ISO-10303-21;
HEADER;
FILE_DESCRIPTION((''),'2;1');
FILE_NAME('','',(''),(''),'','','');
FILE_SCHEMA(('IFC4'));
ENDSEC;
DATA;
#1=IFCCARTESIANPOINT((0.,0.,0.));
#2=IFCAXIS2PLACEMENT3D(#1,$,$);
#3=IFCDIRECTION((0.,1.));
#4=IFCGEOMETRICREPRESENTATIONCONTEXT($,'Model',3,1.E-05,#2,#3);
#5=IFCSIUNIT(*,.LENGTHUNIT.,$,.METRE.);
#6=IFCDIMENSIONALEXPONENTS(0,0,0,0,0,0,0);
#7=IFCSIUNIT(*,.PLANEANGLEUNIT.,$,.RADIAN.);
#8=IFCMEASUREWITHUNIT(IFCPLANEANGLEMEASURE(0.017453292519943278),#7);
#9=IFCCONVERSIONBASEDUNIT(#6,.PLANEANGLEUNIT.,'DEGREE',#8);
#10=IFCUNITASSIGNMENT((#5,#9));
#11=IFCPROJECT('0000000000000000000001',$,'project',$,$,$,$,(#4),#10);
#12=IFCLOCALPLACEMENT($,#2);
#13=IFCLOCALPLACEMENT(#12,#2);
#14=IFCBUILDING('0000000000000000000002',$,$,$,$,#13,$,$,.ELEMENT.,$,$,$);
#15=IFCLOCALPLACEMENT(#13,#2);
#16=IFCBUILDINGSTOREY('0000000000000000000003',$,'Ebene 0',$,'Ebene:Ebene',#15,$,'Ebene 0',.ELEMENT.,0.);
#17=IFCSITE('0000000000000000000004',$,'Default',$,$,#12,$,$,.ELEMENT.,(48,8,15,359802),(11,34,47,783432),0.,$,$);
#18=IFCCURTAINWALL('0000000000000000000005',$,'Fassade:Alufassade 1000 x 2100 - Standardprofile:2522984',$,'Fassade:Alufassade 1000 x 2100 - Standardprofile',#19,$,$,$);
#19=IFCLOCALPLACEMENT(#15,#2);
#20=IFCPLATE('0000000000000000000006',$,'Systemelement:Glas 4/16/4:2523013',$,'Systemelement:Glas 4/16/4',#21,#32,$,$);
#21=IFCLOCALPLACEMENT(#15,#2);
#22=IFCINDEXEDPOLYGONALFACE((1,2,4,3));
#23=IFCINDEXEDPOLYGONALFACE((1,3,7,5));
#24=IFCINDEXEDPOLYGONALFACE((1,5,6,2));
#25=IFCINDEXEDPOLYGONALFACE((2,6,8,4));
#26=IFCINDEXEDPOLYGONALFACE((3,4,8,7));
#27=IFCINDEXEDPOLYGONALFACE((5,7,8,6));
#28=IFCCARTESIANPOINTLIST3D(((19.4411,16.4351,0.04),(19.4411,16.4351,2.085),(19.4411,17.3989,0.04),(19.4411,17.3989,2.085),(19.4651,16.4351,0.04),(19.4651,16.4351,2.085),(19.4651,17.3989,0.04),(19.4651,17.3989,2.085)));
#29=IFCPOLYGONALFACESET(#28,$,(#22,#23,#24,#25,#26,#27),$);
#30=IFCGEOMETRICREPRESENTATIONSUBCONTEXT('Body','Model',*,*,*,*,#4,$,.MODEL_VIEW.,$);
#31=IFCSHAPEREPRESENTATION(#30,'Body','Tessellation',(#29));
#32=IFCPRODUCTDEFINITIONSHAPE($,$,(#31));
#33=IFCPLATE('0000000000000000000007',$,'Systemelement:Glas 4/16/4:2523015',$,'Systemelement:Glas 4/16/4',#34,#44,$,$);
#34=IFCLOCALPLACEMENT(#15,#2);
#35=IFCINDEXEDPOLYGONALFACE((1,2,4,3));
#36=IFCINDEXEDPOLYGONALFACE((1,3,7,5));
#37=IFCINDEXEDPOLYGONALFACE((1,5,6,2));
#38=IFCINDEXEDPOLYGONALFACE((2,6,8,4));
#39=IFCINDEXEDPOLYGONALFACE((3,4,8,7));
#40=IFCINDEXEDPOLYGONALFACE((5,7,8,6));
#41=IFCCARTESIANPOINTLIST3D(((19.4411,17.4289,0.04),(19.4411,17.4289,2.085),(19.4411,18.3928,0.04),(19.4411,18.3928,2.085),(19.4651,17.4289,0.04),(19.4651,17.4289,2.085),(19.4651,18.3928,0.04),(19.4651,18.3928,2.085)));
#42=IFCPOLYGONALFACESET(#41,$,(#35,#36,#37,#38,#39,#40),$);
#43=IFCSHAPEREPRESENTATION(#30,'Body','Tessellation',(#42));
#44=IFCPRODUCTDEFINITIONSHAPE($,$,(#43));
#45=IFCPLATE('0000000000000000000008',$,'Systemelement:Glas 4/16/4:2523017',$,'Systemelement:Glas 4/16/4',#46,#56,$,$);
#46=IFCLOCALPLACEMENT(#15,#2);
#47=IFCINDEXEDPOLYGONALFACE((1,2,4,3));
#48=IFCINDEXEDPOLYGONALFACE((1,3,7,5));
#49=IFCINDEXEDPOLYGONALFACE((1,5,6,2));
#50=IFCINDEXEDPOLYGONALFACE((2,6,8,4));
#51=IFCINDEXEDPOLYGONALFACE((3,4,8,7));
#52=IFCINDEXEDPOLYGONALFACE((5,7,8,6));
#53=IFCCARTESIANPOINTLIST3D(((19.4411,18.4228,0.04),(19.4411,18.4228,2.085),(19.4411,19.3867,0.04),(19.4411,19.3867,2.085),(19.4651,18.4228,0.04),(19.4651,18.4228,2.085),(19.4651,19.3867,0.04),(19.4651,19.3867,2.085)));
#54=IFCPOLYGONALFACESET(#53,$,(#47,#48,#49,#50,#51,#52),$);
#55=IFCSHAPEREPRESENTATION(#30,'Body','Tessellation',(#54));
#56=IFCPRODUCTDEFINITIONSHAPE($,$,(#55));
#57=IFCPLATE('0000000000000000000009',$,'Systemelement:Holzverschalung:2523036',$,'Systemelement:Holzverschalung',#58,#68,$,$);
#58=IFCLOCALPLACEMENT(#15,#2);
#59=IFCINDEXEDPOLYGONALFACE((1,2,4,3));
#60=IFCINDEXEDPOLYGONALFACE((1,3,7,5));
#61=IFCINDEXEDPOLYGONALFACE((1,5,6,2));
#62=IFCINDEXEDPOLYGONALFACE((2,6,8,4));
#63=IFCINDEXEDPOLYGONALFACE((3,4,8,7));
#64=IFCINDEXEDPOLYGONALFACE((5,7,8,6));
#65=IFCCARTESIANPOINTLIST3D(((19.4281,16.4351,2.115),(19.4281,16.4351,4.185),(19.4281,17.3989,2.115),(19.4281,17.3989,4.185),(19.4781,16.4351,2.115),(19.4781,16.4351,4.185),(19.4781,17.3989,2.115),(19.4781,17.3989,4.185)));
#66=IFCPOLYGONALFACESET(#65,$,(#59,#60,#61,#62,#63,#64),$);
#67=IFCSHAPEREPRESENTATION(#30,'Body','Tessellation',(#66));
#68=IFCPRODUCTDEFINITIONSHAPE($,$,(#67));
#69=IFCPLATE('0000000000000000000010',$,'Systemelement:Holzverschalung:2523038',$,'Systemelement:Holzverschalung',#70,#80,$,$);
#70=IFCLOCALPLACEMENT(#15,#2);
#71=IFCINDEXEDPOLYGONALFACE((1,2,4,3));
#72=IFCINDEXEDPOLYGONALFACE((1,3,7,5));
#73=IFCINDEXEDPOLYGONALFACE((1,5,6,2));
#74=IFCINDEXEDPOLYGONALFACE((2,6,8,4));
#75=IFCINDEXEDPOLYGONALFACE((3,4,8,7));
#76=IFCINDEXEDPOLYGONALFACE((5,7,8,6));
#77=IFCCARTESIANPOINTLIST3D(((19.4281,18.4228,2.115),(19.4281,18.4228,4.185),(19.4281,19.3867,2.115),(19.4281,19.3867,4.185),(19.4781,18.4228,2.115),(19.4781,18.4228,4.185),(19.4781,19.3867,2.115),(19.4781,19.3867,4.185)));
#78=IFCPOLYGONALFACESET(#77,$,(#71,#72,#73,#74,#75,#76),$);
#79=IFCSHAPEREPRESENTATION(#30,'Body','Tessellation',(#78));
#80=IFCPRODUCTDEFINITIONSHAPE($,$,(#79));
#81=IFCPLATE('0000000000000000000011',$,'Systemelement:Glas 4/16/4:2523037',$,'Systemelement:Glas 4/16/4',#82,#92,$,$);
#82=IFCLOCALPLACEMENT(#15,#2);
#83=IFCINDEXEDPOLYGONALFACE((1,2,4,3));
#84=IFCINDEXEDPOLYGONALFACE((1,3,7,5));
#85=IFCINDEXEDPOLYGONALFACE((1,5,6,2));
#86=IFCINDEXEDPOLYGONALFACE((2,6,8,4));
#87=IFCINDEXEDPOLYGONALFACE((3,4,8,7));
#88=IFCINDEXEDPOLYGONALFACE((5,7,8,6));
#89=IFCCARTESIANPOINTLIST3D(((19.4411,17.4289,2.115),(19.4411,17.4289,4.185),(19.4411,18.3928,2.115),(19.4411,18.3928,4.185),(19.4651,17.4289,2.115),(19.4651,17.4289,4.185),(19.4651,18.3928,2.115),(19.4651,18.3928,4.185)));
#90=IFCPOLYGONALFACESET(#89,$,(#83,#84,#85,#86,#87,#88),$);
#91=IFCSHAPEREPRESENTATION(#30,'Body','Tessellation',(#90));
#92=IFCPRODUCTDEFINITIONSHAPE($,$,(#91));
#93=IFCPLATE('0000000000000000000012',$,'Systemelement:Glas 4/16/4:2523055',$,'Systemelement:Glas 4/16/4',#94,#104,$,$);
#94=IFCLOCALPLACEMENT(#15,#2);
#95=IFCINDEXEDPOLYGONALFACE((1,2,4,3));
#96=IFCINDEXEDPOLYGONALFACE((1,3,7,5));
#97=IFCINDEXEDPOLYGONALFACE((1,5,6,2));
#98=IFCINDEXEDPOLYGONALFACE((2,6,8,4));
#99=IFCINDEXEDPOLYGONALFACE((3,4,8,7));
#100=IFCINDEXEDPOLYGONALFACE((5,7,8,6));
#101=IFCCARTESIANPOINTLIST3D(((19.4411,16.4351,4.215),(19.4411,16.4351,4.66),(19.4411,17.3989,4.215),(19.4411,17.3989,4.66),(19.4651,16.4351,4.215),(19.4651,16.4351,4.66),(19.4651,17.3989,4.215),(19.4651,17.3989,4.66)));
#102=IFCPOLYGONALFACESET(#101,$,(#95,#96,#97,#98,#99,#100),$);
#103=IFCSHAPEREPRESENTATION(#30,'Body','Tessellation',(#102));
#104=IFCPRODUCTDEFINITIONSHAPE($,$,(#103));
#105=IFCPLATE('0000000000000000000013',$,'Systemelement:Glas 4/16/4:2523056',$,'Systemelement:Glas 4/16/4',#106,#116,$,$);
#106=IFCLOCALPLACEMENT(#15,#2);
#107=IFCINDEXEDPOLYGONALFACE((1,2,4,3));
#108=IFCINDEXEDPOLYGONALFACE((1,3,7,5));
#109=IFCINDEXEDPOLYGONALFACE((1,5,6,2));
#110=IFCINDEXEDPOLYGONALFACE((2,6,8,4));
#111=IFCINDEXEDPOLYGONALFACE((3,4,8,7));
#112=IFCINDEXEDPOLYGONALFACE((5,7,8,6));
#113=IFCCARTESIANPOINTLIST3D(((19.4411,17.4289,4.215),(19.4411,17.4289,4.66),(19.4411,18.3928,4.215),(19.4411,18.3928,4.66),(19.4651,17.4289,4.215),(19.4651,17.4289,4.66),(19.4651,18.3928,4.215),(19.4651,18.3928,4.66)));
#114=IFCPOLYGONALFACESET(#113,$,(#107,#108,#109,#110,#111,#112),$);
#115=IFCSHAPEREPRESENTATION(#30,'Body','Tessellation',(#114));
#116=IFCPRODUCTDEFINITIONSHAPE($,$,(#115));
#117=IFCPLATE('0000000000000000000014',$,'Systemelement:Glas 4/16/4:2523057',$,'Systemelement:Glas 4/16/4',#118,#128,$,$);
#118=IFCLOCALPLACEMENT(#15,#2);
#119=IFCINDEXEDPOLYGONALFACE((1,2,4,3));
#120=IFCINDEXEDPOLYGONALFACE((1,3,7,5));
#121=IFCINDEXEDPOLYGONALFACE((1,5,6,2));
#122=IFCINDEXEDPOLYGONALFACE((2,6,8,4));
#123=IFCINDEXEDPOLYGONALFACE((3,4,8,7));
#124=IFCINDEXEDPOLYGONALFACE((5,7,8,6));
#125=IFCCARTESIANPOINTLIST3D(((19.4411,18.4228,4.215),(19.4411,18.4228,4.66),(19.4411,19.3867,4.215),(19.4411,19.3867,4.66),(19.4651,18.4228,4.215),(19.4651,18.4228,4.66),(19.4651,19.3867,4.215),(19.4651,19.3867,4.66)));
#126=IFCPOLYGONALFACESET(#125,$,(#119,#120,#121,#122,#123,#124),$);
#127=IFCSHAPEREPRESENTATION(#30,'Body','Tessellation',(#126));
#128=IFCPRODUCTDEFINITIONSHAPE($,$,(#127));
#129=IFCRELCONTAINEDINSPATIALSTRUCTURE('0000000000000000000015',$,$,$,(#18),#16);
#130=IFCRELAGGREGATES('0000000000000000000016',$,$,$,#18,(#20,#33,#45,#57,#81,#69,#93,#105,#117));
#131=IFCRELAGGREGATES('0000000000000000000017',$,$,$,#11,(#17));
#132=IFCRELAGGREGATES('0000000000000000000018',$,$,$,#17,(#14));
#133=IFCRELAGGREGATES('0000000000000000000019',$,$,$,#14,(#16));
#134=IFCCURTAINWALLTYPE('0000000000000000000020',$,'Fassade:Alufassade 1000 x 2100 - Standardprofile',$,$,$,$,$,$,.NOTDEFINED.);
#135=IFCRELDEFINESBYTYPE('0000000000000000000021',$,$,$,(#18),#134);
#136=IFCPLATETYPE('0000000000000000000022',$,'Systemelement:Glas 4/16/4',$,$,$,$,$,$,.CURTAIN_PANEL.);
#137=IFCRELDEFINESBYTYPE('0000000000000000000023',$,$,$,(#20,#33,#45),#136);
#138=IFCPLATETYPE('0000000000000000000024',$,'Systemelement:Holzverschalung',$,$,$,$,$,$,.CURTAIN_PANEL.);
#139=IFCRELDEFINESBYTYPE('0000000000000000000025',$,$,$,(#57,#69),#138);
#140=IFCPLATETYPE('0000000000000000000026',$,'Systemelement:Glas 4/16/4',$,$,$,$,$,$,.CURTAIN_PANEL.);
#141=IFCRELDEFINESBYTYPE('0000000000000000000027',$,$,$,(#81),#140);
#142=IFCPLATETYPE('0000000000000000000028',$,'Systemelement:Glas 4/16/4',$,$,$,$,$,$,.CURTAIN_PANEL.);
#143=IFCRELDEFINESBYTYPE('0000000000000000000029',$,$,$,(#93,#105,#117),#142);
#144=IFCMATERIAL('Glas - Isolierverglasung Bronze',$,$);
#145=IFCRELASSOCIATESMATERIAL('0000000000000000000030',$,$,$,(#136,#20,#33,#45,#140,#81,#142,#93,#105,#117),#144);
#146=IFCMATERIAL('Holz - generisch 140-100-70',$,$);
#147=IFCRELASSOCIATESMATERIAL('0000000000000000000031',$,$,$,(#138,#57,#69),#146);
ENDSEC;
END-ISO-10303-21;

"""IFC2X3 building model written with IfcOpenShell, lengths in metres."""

from ifc_helpers import new_model, entity, si_unit, converted_unit, direction, frame, origin, origin_2d_with_axis, place, context, subcontext, project, spatial, rectangle, extrude, source, transform, mapped, material, type_object, type_shapes, element, aggregate, save


model = new_model("IFC2X3")

# Units and contexts
model_context = context("Model", 3, precision=1e-05, world=origin(), true_north=direction((0.0, 1.0)))
body_context = subcontext(model_context, "Body", "Model", "MODEL_VIEW")
ifc_project = project(units=[si_unit("LENGTHUNIT", "METRE"), converted_unit("PLANEANGLEUNIT", "DEGREE", entity("IfcPlaneAngleMeasure", 0.017453292519943278), si_unit("PLANEANGLEUNIT", "RADIAN"), dimensions=[0, 0, 0, 0, 0, 0, 0])], contexts=[model_context])

# Site, building, storey
site_placement = place(None, origin())
site = spatial("IfcSite", under=ifc_project, at=site_placement, Name="Default", CompositionType="ELEMENT", RefLatitude=(48, 8, 15, 359802), RefLongitude=(11, 34, 47, 783432), RefElevation=0.0)
building_placement = place(site_placement, origin())
building = spatial("IfcBuilding", under=site, at=building_placement, CompositionType="ELEMENT")
storey_placement = place(building_placement, origin())
storey = spatial("IfcBuildingStorey", under=building, at=storey_placement, Name="Ebene 0", ObjectType="Ebene:Ebene", LongName="Ebene 0", CompositionType="ELEMENT", Elevation=0.0)

# Curtain wall, plates
curtain_wall_type = type_object("IfcCurtainWallType", Name="Fassade:Alufassade 1000 x 2100 - Standardprofile", PredefinedType="NOTDEFINED")
curtain_wall_placement = place(storey_placement, origin())
curtain_wall = element("IfcCurtainWall", 1, at=curtain_wall_placement, inside=storey, type_object=curtain_wall_type, Name="Fassade:Alufassade 1000 x 2100 - Standardprofile:2522984", ObjectType="Fassade:Alufassade 1000 x 2100 - Standardprofile")
ifc_material_1 = material(Name="Glas - Isolierverglasung Bronze")
plate_type_1 = type_object("IfcPlateType", Name="Systemelement:Glas 4/16/4", PredefinedType="CURTAIN_PANEL", material=ifc_material_1)
shared_shape_1 = source(origin(), body_context, "Body", "SweptSolid", [
    extrude(rectangle(XDim=0.024, YDim=0.9639, at=origin_2d_with_axis()), frame((0.0, 0.0, 0.0), z_axis=(0.0, 0.0, 1.0), x_axis=(0.0, 1.0, 0.0)), (0.0, 0.0, 1.0), 2.045),
])
type_shapes(plate_type_1, [shared_shape_1])
plate_1_placement = place(curtain_wall_placement, frame((19.4531, 16.917, 0.04), z_axis=(0.0, 0.0, 1.0), x_axis=(0.0, 1.0, 0.0)))
plate_1 = element("IfcPlate", 2, at=plate_1_placement, type_object=plate_type_1, material=ifc_material_1, Name="Systemelement:Glas 4/16/4:2523013", ObjectType="Systemelement:Glas 4/16/4", context=body_context, shape_type="MappedRepresentation", body=[
    mapped(shared_shape_1, transform((0.0, 0.0, 0.0), scale=1.0)),
])
plate_2_placement = place(curtain_wall_placement, frame((19.4531, 17.9109, 0.04), z_axis=(0.0, 0.0, 1.0), x_axis=(0.0, 1.0, 0.0)))
plate_2 = element("IfcPlate", 3, at=plate_2_placement, type_object=plate_type_1, material=ifc_material_1, Name="Systemelement:Glas 4/16/4:2523015", ObjectType="Systemelement:Glas 4/16/4", context=body_context, shape_type="MappedRepresentation", body=[
    mapped(shared_shape_1, transform((0.0, 0.0, 0.0), scale=1.0)),
])
plate_3_placement = place(curtain_wall_placement, frame((19.4531, 18.9048, 0.04), z_axis=(0.0, 0.0, 1.0), x_axis=(0.0, 1.0, 0.0)))
plate_3 = element("IfcPlate", 4, at=plate_3_placement, type_object=plate_type_1, material=ifc_material_1, Name="Systemelement:Glas 4/16/4:2523017", ObjectType="Systemelement:Glas 4/16/4", context=body_context, shape_type="MappedRepresentation", body=[
    mapped(shared_shape_1, transform((0.0, 0.0, 0.0), scale=1.0)),
])
ifc_material_2 = material(Name="Holz - generisch 140-100-70")
plate_type_2 = type_object("IfcPlateType", Name="Systemelement:Holzverschalung", PredefinedType="CURTAIN_PANEL", material=ifc_material_2)
shared_shape_2 = source(origin(), body_context, "Body", "SweptSolid", [
    extrude(rectangle(XDim=0.05, YDim=0.9639, at=origin_2d_with_axis()), frame((0.0, 0.0, 0.0), z_axis=(0.0, 0.0, 1.0), x_axis=(0.0, 1.0, 0.0)), (0.0, 0.0, 1.0), 2.07),
])
type_shapes(plate_type_2, [shared_shape_2])
plate_4_placement = place(curtain_wall_placement, frame((19.4531, 16.917, 2.115), z_axis=(0.0, 0.0, 1.0), x_axis=(0.0, 1.0, 0.0)))
plate_4 = element("IfcPlate", 5, at=plate_4_placement, type_object=plate_type_2, material=ifc_material_2, Name="Systemelement:Holzverschalung:2523036", ObjectType="Systemelement:Holzverschalung", context=body_context, shape_type="MappedRepresentation", body=[
    mapped(shared_shape_2, transform((0.0, 0.0, 0.0), scale=1.0)),
])
plate_5_placement = place(curtain_wall_placement, frame((19.4531, 18.9048, 2.115), z_axis=(0.0, 0.0, 1.0), x_axis=(0.0, 1.0, 0.0)))
plate_5 = element("IfcPlate", 6, at=plate_5_placement, type_object=plate_type_2, material=ifc_material_2, Name="Systemelement:Holzverschalung:2523038", ObjectType="Systemelement:Holzverschalung", context=body_context, shape_type="MappedRepresentation", body=[
    mapped(shared_shape_2, transform((0.0, 0.0, 0.0), scale=1.0)),
])
plate_type_3 = type_object("IfcPlateType", Name="Systemelement:Glas 4/16/4", PredefinedType="CURTAIN_PANEL", material=ifc_material_1)
shared_shape_3 = source(origin(), body_context, "Body", "SweptSolid", [
    extrude(rectangle(XDim=0.024, YDim=0.9639, at=origin_2d_with_axis()), frame((0.0, 0.0, 0.0), z_axis=(0.0, 0.0, 1.0), x_axis=(0.0, 1.0, 0.0)), (0.0, 0.0, 1.0), 2.07),
])
type_shapes(plate_type_3, [shared_shape_3])
plate_6_placement = place(curtain_wall_placement, frame((19.4531, 17.9109, 2.115), z_axis=(0.0, 0.0, 1.0), x_axis=(0.0, 1.0, 0.0)))
plate_6 = element("IfcPlate", 7, at=plate_6_placement, type_object=plate_type_3, material=ifc_material_1, Name="Systemelement:Glas 4/16/4:2523037", ObjectType="Systemelement:Glas 4/16/4", context=body_context, shape_type="MappedRepresentation", body=[
    mapped(shared_shape_3, transform((0.0, 0.0, 0.0), scale=1.0)),
])
plate_type_4 = type_object("IfcPlateType", Name="Systemelement:Glas 4/16/4", PredefinedType="CURTAIN_PANEL", material=ifc_material_1)
shared_shape_4 = source(origin(), body_context, "Body", "SweptSolid", [
    extrude(rectangle(XDim=0.024, YDim=0.9639, at=origin_2d_with_axis()), frame((0.0, 0.0, 0.0), z_axis=(0.0, 0.0, 1.0), x_axis=(0.0, 1.0, 0.0)), (0.0, 0.0, 1.0), 0.445),
])
type_shapes(plate_type_4, [shared_shape_4])
plate_7_placement = place(curtain_wall_placement, frame((19.4531, 16.917, 4.215), z_axis=(0.0, 0.0, 1.0), x_axis=(0.0, 1.0, 0.0)))
plate_7 = element("IfcPlate", 8, at=plate_7_placement, type_object=plate_type_4, material=ifc_material_1, Name="Systemelement:Glas 4/16/4:2523055", ObjectType="Systemelement:Glas 4/16/4", context=body_context, shape_type="MappedRepresentation", body=[
    mapped(shared_shape_4, transform((0.0, 0.0, 0.0), scale=1.0)),
])
plate_8_placement = place(curtain_wall_placement, frame((19.4531, 17.9109, 4.215), z_axis=(0.0, 0.0, 1.0), x_axis=(0.0, 1.0, 0.0)))
plate_8 = element("IfcPlate", 9, at=plate_8_placement, type_object=plate_type_4, material=ifc_material_1, Name="Systemelement:Glas 4/16/4:2523056", ObjectType="Systemelement:Glas 4/16/4", context=body_context, shape_type="MappedRepresentation", body=[
    mapped(shared_shape_4, transform((0.0, 0.0, 0.0), scale=1.0)),
])
plate_9_placement = place(curtain_wall_placement, frame((19.4531, 18.9048, 4.215), z_axis=(0.0, 0.0, 1.0), x_axis=(0.0, 1.0, 0.0)))
plate_9 = element("IfcPlate", 10, at=plate_9_placement, type_object=plate_type_4, material=ifc_material_1, Name="Systemelement:Glas 4/16/4:2523057", ObjectType="Systemelement:Glas 4/16/4", context=body_context, shape_type="MappedRepresentation", body=[
    mapped(shared_shape_4, transform((0.0, 0.0, 0.0), scale=1.0)),
])
aggregate(curtain_wall, [plate_1, plate_2, plate_3, plate_4, plate_6, plate_5, plate_7, plate_8, plate_9])

save(model, "model.ifc")
